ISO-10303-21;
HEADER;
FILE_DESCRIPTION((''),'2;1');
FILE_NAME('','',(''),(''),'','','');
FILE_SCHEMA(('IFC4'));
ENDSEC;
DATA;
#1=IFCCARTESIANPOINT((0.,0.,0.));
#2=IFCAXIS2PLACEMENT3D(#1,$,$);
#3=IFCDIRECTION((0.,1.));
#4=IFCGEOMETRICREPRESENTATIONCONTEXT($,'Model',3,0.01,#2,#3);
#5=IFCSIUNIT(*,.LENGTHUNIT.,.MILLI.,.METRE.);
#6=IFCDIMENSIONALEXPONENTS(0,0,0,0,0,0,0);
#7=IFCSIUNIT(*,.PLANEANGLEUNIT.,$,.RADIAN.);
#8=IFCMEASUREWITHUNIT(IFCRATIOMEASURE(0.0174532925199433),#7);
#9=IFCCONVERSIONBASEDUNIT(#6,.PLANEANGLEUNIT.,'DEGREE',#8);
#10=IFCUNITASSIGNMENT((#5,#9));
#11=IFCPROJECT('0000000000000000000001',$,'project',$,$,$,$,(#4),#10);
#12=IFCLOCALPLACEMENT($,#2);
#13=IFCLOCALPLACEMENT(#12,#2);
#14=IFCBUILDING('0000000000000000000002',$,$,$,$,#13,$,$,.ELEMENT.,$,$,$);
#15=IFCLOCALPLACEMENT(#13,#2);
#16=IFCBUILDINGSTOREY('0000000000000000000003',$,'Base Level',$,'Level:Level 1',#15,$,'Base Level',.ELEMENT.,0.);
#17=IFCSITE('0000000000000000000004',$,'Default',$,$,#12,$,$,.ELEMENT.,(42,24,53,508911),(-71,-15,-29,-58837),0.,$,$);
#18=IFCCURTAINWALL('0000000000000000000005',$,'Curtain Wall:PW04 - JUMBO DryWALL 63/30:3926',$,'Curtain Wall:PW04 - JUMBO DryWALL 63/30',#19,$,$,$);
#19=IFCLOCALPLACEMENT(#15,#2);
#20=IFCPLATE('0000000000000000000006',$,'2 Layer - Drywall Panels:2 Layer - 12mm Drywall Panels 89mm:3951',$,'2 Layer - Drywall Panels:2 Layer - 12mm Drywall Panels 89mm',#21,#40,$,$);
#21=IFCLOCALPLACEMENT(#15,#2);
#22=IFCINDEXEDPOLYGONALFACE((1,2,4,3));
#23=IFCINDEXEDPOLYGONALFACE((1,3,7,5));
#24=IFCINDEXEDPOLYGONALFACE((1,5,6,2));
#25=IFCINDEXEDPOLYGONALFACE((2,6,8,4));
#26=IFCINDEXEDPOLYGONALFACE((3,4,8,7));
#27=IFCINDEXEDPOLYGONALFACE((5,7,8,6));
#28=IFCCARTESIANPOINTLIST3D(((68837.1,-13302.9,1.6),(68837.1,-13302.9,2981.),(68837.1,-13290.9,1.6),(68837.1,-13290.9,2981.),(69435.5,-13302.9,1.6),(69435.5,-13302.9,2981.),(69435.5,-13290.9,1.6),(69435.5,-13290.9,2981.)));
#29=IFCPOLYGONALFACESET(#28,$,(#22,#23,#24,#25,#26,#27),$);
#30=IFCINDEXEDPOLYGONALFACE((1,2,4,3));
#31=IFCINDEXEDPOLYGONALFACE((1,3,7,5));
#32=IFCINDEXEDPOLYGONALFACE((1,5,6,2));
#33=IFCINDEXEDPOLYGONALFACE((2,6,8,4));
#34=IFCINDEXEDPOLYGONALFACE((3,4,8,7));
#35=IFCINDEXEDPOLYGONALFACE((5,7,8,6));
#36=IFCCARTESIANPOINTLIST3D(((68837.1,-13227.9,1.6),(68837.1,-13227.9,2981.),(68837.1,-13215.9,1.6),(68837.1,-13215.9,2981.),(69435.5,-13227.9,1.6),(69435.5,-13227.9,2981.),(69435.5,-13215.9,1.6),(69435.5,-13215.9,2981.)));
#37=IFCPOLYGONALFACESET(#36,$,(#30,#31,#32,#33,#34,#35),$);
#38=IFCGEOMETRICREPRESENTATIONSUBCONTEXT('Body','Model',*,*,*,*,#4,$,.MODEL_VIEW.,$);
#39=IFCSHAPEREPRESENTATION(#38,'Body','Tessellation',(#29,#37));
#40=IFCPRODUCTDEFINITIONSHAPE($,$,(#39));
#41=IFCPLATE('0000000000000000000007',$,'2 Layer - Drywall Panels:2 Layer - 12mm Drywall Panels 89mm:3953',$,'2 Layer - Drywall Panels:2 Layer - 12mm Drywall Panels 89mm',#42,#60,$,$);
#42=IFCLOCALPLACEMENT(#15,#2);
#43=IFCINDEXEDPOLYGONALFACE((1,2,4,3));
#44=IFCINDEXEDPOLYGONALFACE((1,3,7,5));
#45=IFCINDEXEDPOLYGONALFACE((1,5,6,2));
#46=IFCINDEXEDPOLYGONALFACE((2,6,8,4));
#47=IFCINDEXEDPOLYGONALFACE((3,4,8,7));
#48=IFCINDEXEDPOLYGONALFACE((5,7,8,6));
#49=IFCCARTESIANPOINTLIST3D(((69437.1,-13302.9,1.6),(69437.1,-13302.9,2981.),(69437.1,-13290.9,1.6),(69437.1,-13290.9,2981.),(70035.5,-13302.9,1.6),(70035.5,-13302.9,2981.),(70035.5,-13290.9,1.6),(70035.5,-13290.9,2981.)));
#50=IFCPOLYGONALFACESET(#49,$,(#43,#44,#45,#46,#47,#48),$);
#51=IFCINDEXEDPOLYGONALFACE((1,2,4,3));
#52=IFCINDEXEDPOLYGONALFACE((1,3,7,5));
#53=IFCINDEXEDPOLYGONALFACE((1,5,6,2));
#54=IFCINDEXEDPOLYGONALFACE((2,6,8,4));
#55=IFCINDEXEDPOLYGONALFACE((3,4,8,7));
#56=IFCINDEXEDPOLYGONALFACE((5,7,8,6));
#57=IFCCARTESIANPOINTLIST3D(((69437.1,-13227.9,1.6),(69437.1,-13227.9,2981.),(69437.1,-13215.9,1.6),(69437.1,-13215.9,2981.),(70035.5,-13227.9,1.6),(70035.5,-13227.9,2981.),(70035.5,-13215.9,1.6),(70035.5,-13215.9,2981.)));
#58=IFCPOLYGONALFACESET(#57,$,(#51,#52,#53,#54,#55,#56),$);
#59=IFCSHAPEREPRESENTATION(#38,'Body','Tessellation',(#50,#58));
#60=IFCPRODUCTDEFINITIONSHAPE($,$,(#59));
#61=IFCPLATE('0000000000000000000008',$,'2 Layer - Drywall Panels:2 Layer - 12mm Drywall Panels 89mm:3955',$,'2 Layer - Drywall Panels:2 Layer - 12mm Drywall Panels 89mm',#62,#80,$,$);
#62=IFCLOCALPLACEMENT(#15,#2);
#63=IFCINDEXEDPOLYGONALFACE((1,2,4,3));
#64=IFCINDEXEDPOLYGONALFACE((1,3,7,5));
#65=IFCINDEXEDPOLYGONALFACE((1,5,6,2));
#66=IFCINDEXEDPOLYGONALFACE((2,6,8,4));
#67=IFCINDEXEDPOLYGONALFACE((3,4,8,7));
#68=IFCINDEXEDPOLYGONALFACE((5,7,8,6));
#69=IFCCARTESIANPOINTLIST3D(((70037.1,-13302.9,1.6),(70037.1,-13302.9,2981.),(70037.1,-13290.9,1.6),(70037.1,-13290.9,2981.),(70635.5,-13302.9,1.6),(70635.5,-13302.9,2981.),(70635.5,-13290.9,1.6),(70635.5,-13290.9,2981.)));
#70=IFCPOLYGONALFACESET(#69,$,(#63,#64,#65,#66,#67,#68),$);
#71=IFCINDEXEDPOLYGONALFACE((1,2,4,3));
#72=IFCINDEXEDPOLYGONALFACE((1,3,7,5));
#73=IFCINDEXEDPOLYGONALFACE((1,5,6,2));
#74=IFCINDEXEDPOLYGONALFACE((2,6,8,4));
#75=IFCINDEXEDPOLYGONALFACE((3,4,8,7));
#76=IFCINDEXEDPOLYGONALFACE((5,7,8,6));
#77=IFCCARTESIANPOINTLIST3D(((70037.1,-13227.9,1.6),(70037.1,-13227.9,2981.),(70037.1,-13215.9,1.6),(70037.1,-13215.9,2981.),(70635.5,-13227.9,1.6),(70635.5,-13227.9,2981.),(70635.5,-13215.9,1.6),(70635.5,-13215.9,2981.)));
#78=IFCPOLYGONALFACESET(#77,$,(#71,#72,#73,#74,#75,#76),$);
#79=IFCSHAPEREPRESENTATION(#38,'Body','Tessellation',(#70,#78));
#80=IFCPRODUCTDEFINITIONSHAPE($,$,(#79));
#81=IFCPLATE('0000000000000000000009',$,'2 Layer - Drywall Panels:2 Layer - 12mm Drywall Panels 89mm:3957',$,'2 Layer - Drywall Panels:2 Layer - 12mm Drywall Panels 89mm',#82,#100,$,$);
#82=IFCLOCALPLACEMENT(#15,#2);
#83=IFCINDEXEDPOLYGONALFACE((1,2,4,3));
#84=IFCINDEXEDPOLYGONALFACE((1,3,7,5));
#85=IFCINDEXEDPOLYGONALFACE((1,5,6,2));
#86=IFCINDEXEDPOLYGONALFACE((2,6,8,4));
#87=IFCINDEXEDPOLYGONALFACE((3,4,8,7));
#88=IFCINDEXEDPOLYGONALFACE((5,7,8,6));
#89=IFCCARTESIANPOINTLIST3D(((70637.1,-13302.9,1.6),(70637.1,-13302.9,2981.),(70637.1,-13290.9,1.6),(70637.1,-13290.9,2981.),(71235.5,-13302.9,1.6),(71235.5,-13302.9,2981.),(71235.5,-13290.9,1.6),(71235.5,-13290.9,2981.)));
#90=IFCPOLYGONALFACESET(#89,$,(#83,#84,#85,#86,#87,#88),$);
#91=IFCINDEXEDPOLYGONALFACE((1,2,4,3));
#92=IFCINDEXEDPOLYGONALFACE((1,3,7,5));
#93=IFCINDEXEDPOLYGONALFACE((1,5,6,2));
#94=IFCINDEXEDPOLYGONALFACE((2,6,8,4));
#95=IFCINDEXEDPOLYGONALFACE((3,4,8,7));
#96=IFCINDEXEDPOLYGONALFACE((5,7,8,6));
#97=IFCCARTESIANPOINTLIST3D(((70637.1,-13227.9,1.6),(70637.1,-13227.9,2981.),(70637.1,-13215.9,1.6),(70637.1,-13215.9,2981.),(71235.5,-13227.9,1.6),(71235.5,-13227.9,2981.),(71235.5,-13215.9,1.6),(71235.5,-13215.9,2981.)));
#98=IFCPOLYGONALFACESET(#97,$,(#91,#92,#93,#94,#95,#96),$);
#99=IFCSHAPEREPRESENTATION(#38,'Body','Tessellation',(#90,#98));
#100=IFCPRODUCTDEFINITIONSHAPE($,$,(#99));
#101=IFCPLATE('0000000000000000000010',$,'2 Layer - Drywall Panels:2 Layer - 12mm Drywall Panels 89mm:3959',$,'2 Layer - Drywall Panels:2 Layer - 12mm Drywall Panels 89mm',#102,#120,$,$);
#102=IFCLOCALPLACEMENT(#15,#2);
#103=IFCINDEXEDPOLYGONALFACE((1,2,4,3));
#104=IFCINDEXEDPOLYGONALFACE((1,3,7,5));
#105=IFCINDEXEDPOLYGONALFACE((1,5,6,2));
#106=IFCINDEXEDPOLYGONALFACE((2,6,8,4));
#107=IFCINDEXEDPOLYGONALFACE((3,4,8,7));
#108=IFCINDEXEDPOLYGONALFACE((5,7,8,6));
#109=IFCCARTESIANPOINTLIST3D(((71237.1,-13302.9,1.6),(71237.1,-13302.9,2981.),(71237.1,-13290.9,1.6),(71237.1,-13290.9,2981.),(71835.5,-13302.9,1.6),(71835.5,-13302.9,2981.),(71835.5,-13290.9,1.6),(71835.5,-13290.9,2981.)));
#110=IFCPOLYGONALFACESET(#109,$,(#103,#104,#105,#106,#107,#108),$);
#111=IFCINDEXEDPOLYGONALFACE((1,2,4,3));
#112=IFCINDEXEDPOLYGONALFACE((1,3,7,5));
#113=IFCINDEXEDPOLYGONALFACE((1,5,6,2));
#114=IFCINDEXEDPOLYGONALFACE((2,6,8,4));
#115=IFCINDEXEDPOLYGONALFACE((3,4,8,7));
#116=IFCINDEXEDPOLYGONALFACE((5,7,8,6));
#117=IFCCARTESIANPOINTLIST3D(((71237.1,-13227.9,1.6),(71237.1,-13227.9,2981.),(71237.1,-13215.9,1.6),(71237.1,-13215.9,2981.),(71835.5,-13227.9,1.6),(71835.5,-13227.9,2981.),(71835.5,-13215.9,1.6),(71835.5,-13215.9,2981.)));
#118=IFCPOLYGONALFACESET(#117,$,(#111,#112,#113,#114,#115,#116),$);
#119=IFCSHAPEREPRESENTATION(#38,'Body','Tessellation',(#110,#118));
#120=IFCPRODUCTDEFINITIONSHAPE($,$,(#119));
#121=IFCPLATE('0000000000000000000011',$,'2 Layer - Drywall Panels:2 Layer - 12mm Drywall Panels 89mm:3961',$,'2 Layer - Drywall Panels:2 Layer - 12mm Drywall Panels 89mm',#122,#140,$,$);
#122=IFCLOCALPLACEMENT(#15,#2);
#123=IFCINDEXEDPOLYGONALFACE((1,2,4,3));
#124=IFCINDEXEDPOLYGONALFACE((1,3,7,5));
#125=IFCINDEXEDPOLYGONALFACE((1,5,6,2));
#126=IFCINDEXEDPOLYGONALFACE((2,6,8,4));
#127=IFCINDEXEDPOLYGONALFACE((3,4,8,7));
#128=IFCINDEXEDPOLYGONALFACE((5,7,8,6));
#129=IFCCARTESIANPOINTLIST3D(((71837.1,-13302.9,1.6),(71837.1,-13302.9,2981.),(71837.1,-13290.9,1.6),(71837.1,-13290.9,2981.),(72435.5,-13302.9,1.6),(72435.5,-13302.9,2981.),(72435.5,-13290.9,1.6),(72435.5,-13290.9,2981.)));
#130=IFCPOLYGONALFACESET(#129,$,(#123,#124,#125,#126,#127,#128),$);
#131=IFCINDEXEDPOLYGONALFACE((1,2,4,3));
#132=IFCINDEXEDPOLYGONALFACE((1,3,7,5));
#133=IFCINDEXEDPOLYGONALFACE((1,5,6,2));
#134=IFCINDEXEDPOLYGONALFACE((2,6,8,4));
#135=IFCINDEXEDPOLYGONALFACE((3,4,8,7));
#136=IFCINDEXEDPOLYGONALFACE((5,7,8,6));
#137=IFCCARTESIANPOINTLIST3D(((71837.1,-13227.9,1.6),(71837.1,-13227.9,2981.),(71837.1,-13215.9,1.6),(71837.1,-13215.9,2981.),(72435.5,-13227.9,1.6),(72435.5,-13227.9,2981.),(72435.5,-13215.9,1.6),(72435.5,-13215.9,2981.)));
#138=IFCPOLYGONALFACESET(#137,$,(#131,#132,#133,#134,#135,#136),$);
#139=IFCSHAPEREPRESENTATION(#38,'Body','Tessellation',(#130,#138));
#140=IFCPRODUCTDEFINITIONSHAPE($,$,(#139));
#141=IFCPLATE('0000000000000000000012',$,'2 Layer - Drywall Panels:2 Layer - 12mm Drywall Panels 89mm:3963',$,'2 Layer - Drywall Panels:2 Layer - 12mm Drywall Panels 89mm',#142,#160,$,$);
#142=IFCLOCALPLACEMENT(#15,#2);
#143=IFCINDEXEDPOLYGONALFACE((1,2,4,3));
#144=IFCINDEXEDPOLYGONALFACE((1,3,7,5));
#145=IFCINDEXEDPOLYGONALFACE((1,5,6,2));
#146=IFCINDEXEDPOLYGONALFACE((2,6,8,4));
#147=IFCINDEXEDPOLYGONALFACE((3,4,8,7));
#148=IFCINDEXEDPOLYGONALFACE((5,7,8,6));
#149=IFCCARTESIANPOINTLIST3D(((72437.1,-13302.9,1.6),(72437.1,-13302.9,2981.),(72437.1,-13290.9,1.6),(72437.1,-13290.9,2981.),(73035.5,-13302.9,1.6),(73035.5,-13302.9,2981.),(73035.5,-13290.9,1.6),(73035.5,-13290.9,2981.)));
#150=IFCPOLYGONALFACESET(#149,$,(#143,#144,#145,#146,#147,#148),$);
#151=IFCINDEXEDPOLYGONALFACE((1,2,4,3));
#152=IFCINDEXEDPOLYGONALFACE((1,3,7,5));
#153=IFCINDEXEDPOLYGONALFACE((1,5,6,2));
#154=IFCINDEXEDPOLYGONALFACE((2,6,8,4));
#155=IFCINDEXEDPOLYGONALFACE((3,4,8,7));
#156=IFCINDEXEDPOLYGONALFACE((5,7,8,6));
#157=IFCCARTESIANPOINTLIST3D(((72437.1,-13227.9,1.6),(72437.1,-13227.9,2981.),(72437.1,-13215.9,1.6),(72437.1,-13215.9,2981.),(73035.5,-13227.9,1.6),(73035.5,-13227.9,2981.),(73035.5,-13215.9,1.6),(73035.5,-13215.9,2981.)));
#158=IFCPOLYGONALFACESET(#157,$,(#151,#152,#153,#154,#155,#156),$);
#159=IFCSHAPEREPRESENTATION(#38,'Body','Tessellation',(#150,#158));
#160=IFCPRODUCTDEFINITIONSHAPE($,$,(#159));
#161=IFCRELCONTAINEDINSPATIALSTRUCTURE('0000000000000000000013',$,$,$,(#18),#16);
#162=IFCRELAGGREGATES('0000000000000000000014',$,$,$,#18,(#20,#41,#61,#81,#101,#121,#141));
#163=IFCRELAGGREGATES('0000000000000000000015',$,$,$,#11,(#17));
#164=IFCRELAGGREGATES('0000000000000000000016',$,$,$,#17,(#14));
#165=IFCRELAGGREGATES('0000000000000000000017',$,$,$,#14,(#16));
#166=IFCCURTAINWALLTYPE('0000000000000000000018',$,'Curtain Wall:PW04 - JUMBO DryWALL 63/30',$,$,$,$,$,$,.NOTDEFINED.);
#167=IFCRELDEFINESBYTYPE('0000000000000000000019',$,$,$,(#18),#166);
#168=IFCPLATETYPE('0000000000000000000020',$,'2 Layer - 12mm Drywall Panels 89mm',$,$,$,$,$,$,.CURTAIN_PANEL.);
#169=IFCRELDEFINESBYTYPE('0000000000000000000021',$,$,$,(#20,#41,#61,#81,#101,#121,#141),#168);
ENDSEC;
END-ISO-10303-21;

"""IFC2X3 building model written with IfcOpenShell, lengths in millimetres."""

from ifc_helpers import new_model, entity, si_unit, converted_unit, direction, frame, frame_2d, origin, place, context, subcontext, project, spatial, rectangle, extrude, source, transform, mapped, type_object, type_shapes, element, aggregate, save


model = new_model("IFC2X3")

# Units and contexts
model_context = context("Model", 3, precision=0.01, world=origin(), true_north=direction((0.0, 1.0)))
body_context = subcontext(model_context, "Body", "Model", "MODEL_VIEW")
ifc_project = project(units=[si_unit("LENGTHUNIT", "METRE", prefix="MILLI"), converted_unit("PLANEANGLEUNIT", "DEGREE", entity("IfcRatioMeasure", 0.0174532925199433), si_unit("PLANEANGLEUNIT", "RADIAN"), dimensions=[0, 0, 0, 0, 0, 0, 0])], contexts=[model_context])

# Site, building, storey
site_placement = place(None, origin())
site = spatial("IfcSite", under=ifc_project, at=site_placement, Name="Default", CompositionType="ELEMENT", RefLatitude=(42, 24, 53, 508911), RefLongitude=(-71, -15, -29, -58837), RefElevation=0.0)
building_placement = place(site_placement, origin())
building = spatial("IfcBuilding", under=site, at=building_placement, CompositionType="ELEMENT")
storey_placement = place(building_placement, origin())
storey = spatial("IfcBuildingStorey", under=building, at=storey_placement, Name="Base Level", ObjectType="Level:Level 1", LongName="Base Level", CompositionType="ELEMENT", Elevation=0.0)

# Curtain wall, plates
curtain_wall_type = type_object("IfcCurtainWallType", Name="Curtain Wall:PW04 - JUMBO DryWALL 63/30", PredefinedType="NOTDEFINED")
curtain_wall_placement = place(building_placement, origin())
curtain_wall = element("IfcCurtainWall", 1, at=curtain_wall_placement, inside=storey, type_object=curtain_wall_type, Name="Curtain Wall:PW04 - JUMBO DryWALL 63/30:3926", ObjectType="Curtain Wall:PW04 - JUMBO DryWALL 63/30")
plate_type = type_object("IfcPlateType", Name="2 Layer - 12mm Drywall Panels 89mm", PredefinedType="CURTAIN_PANEL")
shared_shape_1 = source(origin(), body_context, "Body", "SweptSolid", [
    extrude(rectangle(XDim=598.4, YDim=12.0, at=frame_2d((0.0, 0.0), x_axis=(1.0, 0.0))), frame((0.0, -37.5, 0.0), z_axis=(0.0, 0.0, 1.0), x_axis=(-1.0, 0.0, 0.0)), (0.0, 0.0, 1.0), 2979.4),
    extrude(rectangle(XDim=12.0, YDim=598.4, at=frame_2d((0.0, 0.0), x_axis=(1.0, 0.0))), frame((0.0, 37.5, 0.0), z_axis=(0.0, 0.0, 1.0), x_axis=(0.0, 1.0, 0.0)), (0.0, 0.0, 1.0), 2979.4),
])
type_shapes(plate_type, [shared_shape_1])
plate_1_placement = place(curtain_wall_placement, frame((69136.3, -13259.4, 1.6)))
plate_1 = element("IfcPlate", 2, at=plate_1_placement, type_object=plate_type, Name="2 Layer - Drywall Panels:2 Layer - 12mm Drywall Panels 89mm:3951", ObjectType="2 Layer - Drywall Panels:2 Layer - 12mm Drywall Panels 89mm", context=body_context, shape_type="MappedRepresentation", body=[
    mapped(shared_shape_1, transform((0.0, 0.0, 0.0), scale=1.0)),
])
plate_2_placement = place(curtain_wall_placement, frame((69736.3, -13259.4, 1.6)))
plate_2 = element("IfcPlate", 3, at=plate_2_placement, type_object=plate_type, Name="2 Layer - Drywall Panels:2 Layer - 12mm Drywall Panels 89mm:3953", ObjectType="2 Layer - Drywall Panels:2 Layer - 12mm Drywall Panels 89mm", context=body_context, shape_type="MappedRepresentation", body=[
    mapped(shared_shape_1, transform((0.0, 0.0, 0.0), scale=1.0)),
])
plate_3_placement = place(curtain_wall_placement, frame((70336.3, -13259.4, 1.6)))
plate_3 = element("IfcPlate", 4, at=plate_3_placement, type_object=plate_type, Name="2 Layer - Drywall Panels:2 Layer - 12mm Drywall Panels 89mm:3955", ObjectType="2 Layer - Drywall Panels:2 Layer - 12mm Drywall Panels 89mm", context=body_context, shape_type="MappedRepresentation", body=[
    mapped(shared_shape_1, transform((0.0, 0.0, 0.0), scale=1.0)),
])
plate_4_placement = place(curtain_wall_placement, frame((70936.3, -13259.4, 1.6)))
plate_4 = element("IfcPlate", 5, at=plate_4_placement, type_object=plate_type, Name="2 Layer - Drywall Panels:2 Layer - 12mm Drywall Panels 89mm:3957", ObjectType="2 Layer - Drywall Panels:2 Layer - 12mm Drywall Panels 89mm", context=body_context, shape_type="MappedRepresentation", body=[
    mapped(shared_shape_1, transform((0.0, 0.0, 0.0), scale=1.0)),
])
plate_5_placement = place(curtain_wall_placement, frame((71536.3, -13259.4, 1.6)))
plate_5 = element("IfcPlate", 6, at=plate_5_placement, type_object=plate_type, Name="2 Layer - Drywall Panels:2 Layer - 12mm Drywall Panels 89mm:3959", ObjectType="2 Layer - Drywall Panels:2 Layer - 12mm Drywall Panels 89mm", context=body_context, shape_type="MappedRepresentation", body=[
    mapped(shared_shape_1, transform((0.0, 0.0, 0.0), scale=1.0)),
])
plate_6_placement = place(curtain_wall_placement, frame((72136.3, -13259.4, 1.6)))
plate_6 = element("IfcPlate", 7, at=plate_6_placement, type_object=plate_type, Name="2 Layer - Drywall Panels:2 Layer - 12mm Drywall Panels 89mm:3961", ObjectType="2 Layer - Drywall Panels:2 Layer - 12mm Drywall Panels 89mm", context=body_context, shape_type="MappedRepresentation", body=[
    mapped(shared_shape_1, transform((0.0, 0.0, 0.0), scale=1.0)),
])
plate_7_placement = place(curtain_wall_placement, frame((72736.3, -13259.4, 1.6)))
plate_7 = element("IfcPlate", 8, at=plate_7_placement, type_object=plate_type, Name="2 Layer - Drywall Panels:2 Layer - 12mm Drywall Panels 89mm:3963", ObjectType="2 Layer - Drywall Panels:2 Layer - 12mm Drywall Panels 89mm", context=body_context, shape_type="MappedRepresentation", body=[
    mapped(shared_shape_1, transform((0.0, 0.0, 0.0), scale=1.0)),
])
aggregate(curtain_wall, [plate_1, plate_2, plate_3, plate_4, plate_5, plate_6, plate_7])

save(model, "model.ifc")
